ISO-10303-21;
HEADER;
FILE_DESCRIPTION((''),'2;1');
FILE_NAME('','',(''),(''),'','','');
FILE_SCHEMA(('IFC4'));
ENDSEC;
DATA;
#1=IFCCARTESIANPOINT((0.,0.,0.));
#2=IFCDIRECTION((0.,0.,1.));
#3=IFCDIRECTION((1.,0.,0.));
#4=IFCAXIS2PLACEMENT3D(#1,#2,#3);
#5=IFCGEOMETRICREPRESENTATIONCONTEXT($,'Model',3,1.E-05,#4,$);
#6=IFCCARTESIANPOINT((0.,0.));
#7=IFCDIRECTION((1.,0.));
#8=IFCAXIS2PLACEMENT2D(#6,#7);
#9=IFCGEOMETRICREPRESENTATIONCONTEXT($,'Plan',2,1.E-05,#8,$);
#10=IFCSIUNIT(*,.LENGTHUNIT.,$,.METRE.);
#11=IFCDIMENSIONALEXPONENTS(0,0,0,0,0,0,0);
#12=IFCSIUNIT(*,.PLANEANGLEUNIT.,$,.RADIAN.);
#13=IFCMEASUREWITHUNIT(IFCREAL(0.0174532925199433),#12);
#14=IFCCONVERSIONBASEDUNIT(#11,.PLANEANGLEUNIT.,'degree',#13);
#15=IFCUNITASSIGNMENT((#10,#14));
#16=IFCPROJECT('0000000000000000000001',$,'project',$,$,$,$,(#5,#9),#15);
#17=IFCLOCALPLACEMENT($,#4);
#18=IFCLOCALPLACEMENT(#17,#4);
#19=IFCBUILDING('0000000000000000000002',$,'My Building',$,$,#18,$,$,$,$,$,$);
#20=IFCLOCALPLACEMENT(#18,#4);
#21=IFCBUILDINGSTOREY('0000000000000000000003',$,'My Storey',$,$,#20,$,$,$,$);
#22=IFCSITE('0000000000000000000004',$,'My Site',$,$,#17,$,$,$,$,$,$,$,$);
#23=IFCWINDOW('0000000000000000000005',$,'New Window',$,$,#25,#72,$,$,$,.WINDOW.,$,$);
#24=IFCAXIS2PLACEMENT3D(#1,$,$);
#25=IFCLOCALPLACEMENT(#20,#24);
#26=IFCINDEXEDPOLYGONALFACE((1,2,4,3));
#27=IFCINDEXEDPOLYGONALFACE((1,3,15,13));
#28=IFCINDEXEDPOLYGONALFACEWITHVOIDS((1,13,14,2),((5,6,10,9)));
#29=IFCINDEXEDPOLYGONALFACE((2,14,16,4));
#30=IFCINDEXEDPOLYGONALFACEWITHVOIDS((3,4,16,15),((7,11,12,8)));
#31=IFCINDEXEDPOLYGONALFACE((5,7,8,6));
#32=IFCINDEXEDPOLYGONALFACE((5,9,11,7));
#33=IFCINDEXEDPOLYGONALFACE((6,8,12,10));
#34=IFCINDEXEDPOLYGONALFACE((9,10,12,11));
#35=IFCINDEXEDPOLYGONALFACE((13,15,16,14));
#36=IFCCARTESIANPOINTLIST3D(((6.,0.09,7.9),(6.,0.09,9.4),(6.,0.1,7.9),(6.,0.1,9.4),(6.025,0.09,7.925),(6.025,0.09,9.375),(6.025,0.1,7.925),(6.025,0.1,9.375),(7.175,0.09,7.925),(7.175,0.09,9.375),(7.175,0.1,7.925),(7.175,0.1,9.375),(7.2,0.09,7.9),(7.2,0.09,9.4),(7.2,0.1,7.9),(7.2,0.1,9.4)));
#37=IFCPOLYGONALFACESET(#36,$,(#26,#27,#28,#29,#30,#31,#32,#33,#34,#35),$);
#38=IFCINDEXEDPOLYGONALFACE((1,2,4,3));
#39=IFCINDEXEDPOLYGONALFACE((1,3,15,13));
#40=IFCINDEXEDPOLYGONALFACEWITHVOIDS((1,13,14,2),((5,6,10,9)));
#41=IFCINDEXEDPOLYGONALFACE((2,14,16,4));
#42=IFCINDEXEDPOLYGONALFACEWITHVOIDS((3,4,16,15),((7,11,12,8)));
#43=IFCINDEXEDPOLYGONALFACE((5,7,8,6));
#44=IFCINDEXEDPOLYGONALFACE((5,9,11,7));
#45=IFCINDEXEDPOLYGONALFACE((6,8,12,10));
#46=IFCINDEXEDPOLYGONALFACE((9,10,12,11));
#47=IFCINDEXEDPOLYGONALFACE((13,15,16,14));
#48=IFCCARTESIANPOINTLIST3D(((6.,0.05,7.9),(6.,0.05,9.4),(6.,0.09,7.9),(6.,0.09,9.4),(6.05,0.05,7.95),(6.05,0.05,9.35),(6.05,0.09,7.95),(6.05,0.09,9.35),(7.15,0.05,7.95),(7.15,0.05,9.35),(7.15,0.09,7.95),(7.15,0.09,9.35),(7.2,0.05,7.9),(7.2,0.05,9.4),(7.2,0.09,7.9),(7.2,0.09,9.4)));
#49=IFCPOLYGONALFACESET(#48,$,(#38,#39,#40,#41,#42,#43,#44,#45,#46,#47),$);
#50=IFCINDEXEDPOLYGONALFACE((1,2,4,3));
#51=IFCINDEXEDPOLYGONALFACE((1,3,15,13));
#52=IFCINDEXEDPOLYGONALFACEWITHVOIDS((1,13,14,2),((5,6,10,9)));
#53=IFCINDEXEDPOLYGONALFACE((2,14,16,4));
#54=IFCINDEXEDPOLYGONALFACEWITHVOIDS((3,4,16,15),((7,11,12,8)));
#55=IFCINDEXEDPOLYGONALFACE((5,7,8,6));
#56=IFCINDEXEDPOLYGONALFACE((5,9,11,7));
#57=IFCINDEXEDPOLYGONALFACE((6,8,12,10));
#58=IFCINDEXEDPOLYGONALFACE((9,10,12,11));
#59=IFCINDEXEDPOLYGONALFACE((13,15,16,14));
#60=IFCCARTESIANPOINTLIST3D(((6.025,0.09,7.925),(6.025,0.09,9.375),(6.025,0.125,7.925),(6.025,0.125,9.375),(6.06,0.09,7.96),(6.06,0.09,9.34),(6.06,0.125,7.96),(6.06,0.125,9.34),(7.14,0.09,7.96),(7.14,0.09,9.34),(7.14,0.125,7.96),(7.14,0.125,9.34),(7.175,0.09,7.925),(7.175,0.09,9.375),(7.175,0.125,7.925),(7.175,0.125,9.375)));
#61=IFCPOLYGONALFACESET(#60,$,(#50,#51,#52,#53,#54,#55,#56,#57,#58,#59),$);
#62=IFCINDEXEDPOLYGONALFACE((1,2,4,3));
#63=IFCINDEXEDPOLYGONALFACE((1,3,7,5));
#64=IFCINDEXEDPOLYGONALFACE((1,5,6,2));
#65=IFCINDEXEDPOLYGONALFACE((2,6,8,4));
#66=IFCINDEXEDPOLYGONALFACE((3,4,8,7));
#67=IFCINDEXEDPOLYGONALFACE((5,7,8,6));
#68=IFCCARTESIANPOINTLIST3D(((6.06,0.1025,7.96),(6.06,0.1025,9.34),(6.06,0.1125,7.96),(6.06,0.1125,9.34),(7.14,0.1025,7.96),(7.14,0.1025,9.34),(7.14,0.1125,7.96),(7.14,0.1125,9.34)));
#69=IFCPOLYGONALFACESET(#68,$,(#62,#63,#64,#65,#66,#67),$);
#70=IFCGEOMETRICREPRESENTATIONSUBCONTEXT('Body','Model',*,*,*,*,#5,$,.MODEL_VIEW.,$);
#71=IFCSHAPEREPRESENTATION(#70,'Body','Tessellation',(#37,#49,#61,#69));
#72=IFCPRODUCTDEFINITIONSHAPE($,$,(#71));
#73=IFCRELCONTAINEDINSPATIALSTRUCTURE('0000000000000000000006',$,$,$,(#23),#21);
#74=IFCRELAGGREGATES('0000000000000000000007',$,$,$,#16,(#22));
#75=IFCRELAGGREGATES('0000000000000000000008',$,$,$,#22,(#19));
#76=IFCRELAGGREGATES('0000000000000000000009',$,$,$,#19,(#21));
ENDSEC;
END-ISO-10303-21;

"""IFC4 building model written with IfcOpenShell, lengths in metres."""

from ifc_helpers import new_model, entity, si_unit, converted_unit, frame, origin_with_axes, origin_2d_with_axis, place, context, subcontext, project, spatial, line, indexed_curve, outline, extrude, element, save


model = new_model("IFC4")

# Units and contexts
model_context = context("Model", 3, precision=1e-05, world=origin_with_axes())
plan_context = context("Plan", 2, precision=1e-05, world=origin_2d_with_axis())
body_context = subcontext(model_context, "Body", "Model", "MODEL_VIEW")
ifc_project = project(units=[si_unit("LENGTHUNIT", "METRE"), converted_unit("PLANEANGLEUNIT", "degree", entity("IfcReal", 0.0174532925199433), si_unit("PLANEANGLEUNIT", "RADIAN"), dimensions=[0, 0, 0, 0, 0, 0, 0])], contexts=[model_context, plan_context])

# Site, building, storey
site_placement = place(None, origin_with_axes())
site = spatial("IfcSite", under=ifc_project, at=site_placement, Name="My Site")
building_placement = place(site_placement, origin_with_axes())
building = spatial("IfcBuilding", under=site, at=building_placement, Name="My Building")
storey_placement = place(building_placement, origin_with_axes())
storey = spatial("IfcBuildingStorey", under=building, at=storey_placement, Name="My Storey")

# Window
window_placement = place(storey_placement, frame((6.0, 0.0, 7.9), z_axis=(0.0, 0.0, 1.0), x_axis=(1.0, 0.0, 0.0)))
element("IfcWindow", 1, at=window_placement, inside=storey, Name="New Window", PredefinedType="WINDOW", context=body_context, shape_type="SweptSolid", body=[
    extrude(outline(indexed_curve([(0.0, 0.0), (1.2, 0.0), (1.2, 1.5), (0.0, 1.5)], segments=[line(1, 2, 3, 4, 1)]), holes=[indexed_curve([(0.025, 0.025), (1.175, 0.025), (1.175, 1.475), (0.025, 1.475)], segments=[line(1, 2, 3, 4, 1)])]), frame((0.0, 0.09, 0.0), z_axis=(0.0, -1.0, 0.0), x_axis=(1.0, 0.0, 0.0)), (0.0, 0.0, -1.0), 0.01),
    extrude(outline(indexed_curve([(0.0, 0.0), (1.2, 0.0), (1.2, 1.5), (0.0, 1.5)], segments=[line(1, 2, 3, 4, 1)]), holes=[indexed_curve([(0.05, 0.05), (1.15, 0.05), (1.15, 1.45), (0.05, 1.45)], segments=[line(1, 2, 3, 4, 1)])]), frame((0.0, 0.05, 0.0), z_axis=(0.0, -1.0, 0.0), x_axis=(1.0, 0.0, 0.0)), (0.0, 0.0, -1.0), 0.04),
    extrude(outline(indexed_curve([(0.0, 0.0), (1.15, 0.0), (1.15, 1.45), (0.0, 1.45)], segments=[line(1, 2, 3, 4, 1)]), holes=[indexed_curve([(0.035, 0.035), (1.115, 0.035), (1.115, 1.415), (0.035, 1.415)], segments=[line(1, 2, 3, 4, 1)])]), frame((0.025, 0.09, 0.025), z_axis=(0.0, -1.0, 0.0), x_axis=(1.0, 0.0, 0.0)), (0.0, 0.0, -1.0), 0.035),
    extrude(outline(indexed_curve([(0.035, 0.035), (1.115, 0.035), (1.115, 1.415), (0.035, 1.415)], segments=[line(1, 2, 3, 4, 1)])), frame((0.025, 0.1025, 0.025), z_axis=(0.0, -1.0, 0.0), x_axis=(1.0, 0.0, 0.0)), (0.0, 0.0, -1.0), 0.01),
])

save(model, "model.ifc")
